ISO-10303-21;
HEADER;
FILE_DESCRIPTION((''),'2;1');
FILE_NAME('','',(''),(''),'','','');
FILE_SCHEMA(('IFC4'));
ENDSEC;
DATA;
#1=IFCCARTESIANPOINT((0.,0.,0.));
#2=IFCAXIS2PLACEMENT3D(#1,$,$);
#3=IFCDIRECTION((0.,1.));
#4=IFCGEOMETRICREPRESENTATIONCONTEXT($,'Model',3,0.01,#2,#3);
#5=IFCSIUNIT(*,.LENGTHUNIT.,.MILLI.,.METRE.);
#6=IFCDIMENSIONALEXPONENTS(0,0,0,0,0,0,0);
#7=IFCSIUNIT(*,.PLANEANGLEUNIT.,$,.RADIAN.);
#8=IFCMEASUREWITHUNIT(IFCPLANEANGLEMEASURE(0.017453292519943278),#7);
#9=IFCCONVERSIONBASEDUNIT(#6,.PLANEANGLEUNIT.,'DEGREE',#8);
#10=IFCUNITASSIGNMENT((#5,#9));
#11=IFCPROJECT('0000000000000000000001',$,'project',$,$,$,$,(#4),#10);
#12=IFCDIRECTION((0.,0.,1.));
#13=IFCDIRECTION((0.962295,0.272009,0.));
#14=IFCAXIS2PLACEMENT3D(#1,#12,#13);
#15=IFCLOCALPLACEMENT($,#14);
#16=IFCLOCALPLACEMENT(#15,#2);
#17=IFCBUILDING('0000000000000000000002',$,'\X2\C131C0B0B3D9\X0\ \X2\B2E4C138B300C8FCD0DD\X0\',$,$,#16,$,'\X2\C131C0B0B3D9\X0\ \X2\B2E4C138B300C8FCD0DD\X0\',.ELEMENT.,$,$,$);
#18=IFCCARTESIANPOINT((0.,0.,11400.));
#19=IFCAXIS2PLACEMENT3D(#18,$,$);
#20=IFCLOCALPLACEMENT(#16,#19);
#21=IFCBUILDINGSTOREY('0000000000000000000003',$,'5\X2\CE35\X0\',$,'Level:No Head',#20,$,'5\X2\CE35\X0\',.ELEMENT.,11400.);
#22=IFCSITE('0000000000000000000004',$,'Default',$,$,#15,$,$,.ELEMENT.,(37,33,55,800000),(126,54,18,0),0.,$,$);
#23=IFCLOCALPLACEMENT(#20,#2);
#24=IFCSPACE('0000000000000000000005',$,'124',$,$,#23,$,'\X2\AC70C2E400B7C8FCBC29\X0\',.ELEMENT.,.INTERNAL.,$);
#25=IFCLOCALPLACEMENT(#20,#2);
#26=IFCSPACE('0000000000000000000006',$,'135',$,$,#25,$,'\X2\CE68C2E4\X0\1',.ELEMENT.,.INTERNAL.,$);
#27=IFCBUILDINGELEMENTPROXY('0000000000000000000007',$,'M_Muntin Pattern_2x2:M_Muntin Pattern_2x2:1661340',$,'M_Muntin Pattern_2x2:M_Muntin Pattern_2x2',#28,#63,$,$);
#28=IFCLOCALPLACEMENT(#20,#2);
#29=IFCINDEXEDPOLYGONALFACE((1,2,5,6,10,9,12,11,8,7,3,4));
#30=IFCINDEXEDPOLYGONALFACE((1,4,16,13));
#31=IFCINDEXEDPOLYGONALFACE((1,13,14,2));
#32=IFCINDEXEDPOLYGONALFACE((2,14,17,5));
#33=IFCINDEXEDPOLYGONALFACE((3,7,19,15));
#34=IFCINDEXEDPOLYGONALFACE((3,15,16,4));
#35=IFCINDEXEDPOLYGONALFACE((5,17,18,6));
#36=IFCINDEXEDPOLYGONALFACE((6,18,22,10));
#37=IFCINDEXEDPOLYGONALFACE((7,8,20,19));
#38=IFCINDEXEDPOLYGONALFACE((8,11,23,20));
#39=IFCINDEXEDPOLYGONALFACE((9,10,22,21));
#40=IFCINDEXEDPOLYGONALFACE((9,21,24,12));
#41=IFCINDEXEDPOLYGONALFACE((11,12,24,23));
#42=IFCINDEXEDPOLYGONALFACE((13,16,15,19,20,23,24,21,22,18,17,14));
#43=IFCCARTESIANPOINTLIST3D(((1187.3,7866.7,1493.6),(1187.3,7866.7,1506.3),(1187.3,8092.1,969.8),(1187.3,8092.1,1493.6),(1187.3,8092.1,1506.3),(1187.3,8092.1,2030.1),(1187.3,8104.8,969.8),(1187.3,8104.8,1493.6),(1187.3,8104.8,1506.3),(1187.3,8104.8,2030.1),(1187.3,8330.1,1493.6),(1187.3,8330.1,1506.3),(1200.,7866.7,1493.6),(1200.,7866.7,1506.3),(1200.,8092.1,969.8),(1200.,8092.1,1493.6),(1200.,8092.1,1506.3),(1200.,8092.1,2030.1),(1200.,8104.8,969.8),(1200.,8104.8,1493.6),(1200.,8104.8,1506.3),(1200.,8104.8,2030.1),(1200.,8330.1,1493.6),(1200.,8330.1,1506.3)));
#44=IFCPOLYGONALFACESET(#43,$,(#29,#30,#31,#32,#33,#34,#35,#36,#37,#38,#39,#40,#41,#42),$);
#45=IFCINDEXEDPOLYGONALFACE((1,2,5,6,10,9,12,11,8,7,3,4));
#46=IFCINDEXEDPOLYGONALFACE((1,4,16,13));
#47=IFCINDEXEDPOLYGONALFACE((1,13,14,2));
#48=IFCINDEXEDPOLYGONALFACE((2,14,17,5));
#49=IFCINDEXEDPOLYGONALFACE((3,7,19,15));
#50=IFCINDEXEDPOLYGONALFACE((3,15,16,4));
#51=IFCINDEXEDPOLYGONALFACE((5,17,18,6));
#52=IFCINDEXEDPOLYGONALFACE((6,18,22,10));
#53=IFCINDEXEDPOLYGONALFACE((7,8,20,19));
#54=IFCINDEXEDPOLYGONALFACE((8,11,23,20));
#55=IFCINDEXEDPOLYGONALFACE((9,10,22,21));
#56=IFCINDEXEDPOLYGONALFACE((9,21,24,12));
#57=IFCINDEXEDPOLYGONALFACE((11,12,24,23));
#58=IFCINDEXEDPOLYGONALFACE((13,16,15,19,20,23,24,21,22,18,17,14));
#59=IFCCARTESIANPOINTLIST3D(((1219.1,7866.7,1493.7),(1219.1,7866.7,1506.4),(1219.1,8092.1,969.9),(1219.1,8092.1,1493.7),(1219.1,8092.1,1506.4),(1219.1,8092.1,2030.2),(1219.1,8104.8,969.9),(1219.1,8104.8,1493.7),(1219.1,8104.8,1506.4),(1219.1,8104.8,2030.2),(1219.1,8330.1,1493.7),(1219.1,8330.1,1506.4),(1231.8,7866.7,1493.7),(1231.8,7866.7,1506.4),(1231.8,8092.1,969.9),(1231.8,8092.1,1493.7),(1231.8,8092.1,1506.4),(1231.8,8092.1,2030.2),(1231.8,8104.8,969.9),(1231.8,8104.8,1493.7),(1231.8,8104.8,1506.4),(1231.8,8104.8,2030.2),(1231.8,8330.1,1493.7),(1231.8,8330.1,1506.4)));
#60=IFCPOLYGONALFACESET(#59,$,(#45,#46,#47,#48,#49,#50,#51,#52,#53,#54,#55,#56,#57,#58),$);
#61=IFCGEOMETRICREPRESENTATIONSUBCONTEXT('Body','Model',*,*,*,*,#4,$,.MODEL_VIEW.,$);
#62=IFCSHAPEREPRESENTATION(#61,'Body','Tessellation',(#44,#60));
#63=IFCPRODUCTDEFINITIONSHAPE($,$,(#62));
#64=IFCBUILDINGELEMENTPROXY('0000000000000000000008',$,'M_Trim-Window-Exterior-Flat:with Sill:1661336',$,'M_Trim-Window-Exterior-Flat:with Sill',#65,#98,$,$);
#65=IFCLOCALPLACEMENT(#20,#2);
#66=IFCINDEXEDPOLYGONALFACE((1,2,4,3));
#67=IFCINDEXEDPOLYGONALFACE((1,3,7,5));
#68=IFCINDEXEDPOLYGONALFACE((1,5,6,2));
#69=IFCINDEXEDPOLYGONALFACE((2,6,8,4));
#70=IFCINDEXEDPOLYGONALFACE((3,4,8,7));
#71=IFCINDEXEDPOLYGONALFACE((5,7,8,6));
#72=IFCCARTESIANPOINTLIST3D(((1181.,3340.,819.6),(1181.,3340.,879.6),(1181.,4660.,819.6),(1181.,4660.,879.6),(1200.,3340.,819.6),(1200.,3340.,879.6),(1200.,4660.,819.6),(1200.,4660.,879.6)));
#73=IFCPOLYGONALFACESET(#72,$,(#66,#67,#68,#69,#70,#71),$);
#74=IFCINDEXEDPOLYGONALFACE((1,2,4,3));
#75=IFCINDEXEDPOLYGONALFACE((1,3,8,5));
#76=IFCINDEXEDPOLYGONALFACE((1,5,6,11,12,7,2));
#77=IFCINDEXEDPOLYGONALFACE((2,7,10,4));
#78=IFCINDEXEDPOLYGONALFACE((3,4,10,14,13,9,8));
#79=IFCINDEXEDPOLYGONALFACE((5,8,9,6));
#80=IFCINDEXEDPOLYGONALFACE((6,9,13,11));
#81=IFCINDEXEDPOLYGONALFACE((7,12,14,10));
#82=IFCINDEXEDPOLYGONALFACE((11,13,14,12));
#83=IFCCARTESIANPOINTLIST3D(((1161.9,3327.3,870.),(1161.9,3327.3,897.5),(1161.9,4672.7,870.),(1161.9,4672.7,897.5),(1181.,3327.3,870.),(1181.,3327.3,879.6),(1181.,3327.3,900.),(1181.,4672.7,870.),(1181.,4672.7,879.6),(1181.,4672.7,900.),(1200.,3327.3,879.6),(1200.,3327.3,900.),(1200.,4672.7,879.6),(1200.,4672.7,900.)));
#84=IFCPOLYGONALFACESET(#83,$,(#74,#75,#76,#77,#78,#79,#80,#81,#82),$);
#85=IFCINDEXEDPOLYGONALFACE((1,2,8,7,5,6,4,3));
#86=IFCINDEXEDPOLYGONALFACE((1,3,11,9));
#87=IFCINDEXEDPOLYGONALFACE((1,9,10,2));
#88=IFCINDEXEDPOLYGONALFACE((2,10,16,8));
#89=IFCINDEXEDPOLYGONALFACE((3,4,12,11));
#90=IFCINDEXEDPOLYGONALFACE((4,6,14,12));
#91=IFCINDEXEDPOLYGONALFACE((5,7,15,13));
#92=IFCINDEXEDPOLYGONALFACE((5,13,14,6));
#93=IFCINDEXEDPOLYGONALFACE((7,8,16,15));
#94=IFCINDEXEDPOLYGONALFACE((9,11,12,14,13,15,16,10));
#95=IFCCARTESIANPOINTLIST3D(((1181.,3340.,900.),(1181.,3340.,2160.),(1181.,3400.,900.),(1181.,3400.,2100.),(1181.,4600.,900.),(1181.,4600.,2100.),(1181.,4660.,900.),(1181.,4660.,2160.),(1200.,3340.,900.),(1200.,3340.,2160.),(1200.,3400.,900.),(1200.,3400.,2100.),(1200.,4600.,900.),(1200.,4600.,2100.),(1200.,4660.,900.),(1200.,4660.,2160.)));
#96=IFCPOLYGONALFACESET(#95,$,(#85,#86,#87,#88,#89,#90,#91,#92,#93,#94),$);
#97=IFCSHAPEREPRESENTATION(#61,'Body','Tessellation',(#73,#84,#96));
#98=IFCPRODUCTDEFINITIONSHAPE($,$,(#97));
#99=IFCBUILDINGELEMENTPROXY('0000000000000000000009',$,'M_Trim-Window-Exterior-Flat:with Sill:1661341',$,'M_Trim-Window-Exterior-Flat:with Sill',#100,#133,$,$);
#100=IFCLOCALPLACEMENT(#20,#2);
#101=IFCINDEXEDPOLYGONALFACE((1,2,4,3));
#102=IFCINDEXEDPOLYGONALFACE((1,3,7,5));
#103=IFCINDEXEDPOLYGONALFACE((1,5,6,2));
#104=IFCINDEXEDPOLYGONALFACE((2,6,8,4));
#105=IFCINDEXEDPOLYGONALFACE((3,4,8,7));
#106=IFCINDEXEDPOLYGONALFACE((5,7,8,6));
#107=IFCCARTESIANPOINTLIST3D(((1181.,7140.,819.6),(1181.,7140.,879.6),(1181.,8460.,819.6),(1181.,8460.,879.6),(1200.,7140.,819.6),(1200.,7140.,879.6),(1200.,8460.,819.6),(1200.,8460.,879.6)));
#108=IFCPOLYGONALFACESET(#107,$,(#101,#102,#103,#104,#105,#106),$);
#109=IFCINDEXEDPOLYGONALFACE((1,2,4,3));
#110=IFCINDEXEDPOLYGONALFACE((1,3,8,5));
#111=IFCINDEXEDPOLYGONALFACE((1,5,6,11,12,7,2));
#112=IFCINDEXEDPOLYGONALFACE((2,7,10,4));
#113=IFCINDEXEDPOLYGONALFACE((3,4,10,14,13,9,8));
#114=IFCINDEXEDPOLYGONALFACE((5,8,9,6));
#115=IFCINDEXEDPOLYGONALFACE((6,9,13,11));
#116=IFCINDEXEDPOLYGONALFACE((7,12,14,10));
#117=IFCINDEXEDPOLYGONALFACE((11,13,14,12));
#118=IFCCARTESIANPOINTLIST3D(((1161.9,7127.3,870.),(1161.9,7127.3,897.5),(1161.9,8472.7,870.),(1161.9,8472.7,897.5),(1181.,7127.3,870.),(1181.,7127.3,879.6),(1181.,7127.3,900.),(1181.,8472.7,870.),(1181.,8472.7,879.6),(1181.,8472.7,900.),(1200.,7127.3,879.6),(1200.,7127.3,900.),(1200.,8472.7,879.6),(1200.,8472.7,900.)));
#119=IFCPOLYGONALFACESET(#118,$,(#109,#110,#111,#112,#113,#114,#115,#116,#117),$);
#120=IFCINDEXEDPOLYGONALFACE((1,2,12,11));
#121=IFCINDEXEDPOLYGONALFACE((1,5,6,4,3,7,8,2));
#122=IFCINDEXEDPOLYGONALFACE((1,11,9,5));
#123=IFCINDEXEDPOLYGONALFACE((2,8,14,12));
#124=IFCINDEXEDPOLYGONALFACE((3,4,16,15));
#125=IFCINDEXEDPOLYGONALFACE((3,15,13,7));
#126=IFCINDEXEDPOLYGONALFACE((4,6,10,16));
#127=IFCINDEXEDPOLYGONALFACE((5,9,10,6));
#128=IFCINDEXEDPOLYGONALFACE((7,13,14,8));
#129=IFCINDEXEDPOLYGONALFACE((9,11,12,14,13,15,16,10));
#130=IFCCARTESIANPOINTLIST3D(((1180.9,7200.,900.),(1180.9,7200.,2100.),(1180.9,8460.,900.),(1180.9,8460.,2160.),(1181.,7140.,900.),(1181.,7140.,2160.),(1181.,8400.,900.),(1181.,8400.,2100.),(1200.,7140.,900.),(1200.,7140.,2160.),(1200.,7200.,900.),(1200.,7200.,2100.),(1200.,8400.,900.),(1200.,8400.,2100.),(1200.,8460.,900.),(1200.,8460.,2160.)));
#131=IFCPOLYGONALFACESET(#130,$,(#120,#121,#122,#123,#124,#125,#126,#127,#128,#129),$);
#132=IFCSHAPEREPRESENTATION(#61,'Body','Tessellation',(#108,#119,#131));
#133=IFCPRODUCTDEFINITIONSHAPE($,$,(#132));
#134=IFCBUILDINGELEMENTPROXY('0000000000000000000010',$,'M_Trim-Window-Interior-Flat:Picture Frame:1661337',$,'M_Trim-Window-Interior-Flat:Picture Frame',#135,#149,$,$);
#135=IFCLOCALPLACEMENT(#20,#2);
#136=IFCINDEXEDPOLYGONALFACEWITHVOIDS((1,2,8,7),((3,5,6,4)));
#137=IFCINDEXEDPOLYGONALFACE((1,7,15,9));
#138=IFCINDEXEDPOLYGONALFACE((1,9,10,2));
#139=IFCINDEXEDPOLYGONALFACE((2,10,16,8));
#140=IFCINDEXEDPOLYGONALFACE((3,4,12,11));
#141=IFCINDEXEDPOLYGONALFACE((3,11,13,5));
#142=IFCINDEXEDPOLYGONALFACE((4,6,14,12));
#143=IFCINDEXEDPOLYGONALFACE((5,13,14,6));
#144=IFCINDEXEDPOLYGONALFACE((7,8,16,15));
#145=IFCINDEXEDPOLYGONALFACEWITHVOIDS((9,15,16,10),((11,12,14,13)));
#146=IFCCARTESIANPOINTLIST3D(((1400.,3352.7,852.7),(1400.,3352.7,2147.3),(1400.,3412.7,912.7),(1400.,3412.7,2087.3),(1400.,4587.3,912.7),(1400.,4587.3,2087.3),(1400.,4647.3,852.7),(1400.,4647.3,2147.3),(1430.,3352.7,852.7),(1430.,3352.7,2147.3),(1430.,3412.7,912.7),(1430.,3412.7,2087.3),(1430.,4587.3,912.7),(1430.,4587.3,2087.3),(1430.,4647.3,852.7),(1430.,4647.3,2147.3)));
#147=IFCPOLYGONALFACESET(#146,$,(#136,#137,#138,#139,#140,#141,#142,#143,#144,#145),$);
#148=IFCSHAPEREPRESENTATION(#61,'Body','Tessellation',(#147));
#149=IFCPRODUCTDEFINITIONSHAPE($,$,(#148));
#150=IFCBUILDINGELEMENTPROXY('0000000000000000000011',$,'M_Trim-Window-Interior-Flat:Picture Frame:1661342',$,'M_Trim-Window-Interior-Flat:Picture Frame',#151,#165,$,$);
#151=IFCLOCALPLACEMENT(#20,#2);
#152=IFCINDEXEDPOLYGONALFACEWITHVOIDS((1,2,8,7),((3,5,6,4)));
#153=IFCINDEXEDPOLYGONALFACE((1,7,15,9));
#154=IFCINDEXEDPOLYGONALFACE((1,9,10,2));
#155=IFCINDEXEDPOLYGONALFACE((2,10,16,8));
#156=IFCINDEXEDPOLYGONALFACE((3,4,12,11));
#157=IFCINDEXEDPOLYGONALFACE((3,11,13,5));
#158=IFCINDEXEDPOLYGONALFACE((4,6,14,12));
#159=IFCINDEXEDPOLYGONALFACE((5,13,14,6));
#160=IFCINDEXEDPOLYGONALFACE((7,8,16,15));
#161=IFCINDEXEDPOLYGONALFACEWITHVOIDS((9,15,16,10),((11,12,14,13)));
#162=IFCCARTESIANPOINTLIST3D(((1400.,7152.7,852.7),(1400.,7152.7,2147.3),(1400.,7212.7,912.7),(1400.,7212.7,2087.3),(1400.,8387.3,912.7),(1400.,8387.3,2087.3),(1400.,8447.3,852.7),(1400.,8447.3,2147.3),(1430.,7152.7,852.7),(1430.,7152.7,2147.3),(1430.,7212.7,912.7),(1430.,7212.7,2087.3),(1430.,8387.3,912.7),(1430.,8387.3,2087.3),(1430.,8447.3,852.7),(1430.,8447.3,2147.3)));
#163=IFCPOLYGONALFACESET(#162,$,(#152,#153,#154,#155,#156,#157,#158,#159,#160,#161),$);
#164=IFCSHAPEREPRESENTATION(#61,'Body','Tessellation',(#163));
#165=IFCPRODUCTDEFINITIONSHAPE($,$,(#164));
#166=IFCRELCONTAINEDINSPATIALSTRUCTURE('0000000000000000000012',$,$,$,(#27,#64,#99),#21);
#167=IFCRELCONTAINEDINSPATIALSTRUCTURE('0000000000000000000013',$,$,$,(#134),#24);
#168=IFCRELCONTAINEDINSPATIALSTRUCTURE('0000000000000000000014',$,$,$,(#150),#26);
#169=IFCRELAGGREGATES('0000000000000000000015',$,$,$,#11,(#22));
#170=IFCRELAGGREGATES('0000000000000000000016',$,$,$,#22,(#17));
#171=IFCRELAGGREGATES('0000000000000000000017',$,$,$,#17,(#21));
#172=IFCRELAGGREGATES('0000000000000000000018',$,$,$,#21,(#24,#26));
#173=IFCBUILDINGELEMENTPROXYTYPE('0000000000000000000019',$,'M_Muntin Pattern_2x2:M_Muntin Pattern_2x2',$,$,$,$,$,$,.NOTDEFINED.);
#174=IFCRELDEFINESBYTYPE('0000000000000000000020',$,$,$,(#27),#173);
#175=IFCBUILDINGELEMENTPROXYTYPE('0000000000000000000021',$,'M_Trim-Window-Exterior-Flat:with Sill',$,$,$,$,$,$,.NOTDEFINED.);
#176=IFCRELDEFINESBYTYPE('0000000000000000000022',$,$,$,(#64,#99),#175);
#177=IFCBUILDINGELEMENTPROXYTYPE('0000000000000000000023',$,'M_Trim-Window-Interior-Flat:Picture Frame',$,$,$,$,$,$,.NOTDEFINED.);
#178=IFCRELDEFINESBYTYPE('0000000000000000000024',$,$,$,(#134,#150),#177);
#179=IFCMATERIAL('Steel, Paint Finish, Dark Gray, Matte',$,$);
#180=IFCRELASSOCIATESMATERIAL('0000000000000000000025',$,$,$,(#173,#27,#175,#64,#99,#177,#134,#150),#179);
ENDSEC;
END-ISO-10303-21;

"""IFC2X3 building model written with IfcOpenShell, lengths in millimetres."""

from ifc_helpers import new_model, entity, si_unit, converted_unit, direction, frame, frame_2d, origin, place, context, subcontext, project, spatial, polyline, rectangle, outline, extrude, source, transform, mapped, material, type_object, type_shapes, element, save


model = new_model("IFC2X3")

# Units and contexts
model_context = context("Model", 3, precision=0.01, world=origin(), true_north=direction((0.0, 1.0)))
body_context = subcontext(model_context, "Body", "Model", "MODEL_VIEW")
ifc_project = project(units=[si_unit("LENGTHUNIT", "METRE", prefix="MILLI"), converted_unit("PLANEANGLEUNIT", "DEGREE", entity("IfcPlaneAngleMeasure", 0.017453292519943278), si_unit("PLANEANGLEUNIT", "RADIAN"), dimensions=[0, 0, 0, 0, 0, 0, 0])], contexts=[model_context])

# Site, building, storey
site_placement = place(None, frame((0.0, 0.0, 0.0), z_axis=(0.0, 0.0, 1.0), x_axis=(0.962295, 0.272009, 0.0)))
site = spatial("IfcSite", under=ifc_project, at=site_placement, Name="Default", CompositionType="ELEMENT", RefLatitude=(37, 33, 55, 800000), RefLongitude=(126, 54, 18, 0), RefElevation=0.0)
building_placement = place(site_placement, origin())
building = spatial("IfcBuilding", under=site, at=building_placement, Name="성산동 다세대주택", LongName="성산동 다세대주택", CompositionType="ELEMENT")
storey_placement = place(building_placement, frame((0.0, 0.0, 11400.0)))
storey = spatial("IfcBuildingStorey", under=building, at=storey_placement, Name="5층", ObjectType="Level:No Head", LongName="5층", CompositionType="ELEMENT", Elevation=11400.0)

# Shared definitions
space_1_placement = place(storey_placement, origin())
space_1 = spatial("IfcSpace", under=storey, at=space_1_placement, Name="124", LongName="거실·주방", CompositionType="ELEMENT", InteriorOrExteriorSpace="INTERNAL")

# Shared definitions
space_2_placement = place(storey_placement, origin())
space_2 = spatial("IfcSpace", under=storey, at=space_2_placement, Name="135", LongName="침실1", CompositionType="ELEMENT", InteriorOrExteriorSpace="INTERNAL")

# Building element proxies
ifc_material_1 = material(Name="Steel, Paint Finish, Dark Gray, Matte")
building_element_proxy_type_1 = type_object("IfcBuildingElementProxyType", Name="M_Muntin Pattern_2x2:M_Muntin Pattern_2x2", PredefinedType="NOTDEFINED", material=ifc_material_1)
shared_shape_1 = source(origin(), body_context, "Body", "SweptSolid", [
    extrude(outline(polyline([(6.4, -6.4), (530.1, -6.4), (530.1, 6.3), (6.4, 6.3), (6.4, 231.7), (-6.3, 231.7), (-6.3, 6.3), (-530.2, 6.3), (-530.2, -6.4), (-6.3, -6.4), (-6.3, -231.7), (6.4, -231.7), (6.4, -6.4)])), frame((0.0, -22.2, 530.1), z_axis=(0.0, 1.0, 0.0), x_axis=(0.0, 0.0, 1.0)), (0.0, 0.0, 1.0), 12.7),
    extrude(outline(polyline([(6.4, -6.4), (530.2, -6.4), (530.2, 6.3), (6.4, 6.3), (6.4, 231.7), (-6.3, 231.7), (-6.3, 6.3), (-530.2, 6.3), (-530.2, -6.4), (-6.3, -6.4), (-6.3, -231.7), (6.4, -231.7), (6.4, -6.4)])), frame((0.0, 9.5, 530.2), z_axis=(0.0, 1.0, 0.0), x_axis=(0.0, 0.0, 1.0)), (0.0, 0.0, 1.0), 12.7),
])
type_shapes(building_element_proxy_type_1, [shared_shape_1])
for number, where, z_axis, x_axis, name in (
    (1, (1209.5, 8098.4, 969.9), (0.0, 0.0, 1.0), (0.0, -1.0, 0.0), "M_Muntin Pattern_2x2:M_Muntin Pattern_2x2:1661340"),
):
    element("IfcBuildingElementProxy", number, at=place(storey_placement, frame(where, z_axis=z_axis, x_axis=x_axis)), inside=storey, type_object=building_element_proxy_type_1, material=ifc_material_1, Name=name, ObjectType="M_Muntin Pattern_2x2:M_Muntin Pattern_2x2", context=body_context, shape_type="MappedRepresentation", body=[
        mapped(shared_shape_1, transform((0.0, 0.0, 0.0), scale=1.0)),
    ])
building_element_proxy_type_2 = type_object("IfcBuildingElementProxyType", Name="M_Trim-Window-Exterior-Flat:with Sill", PredefinedType="NOTDEFINED", material=ifc_material_1)
shared_shape_2 = source(origin(), body_context, "Body", "SweptSolid", [
    extrude(rectangle(XDim=1320.0, YDim=60.0, at=frame_2d((0.0, 0.0), x_axis=(1.0, 0.0))), frame((0.0, -1250.4, 0.0), z_axis=(0.0, 0.0, 1.0), x_axis=(-1.0, 0.0, 0.0)), (0.0, 0.0, 1.0), 19.0),
    extrude(outline(polyline([(-19.0, -15.2), (0.0, -15.2), (0.0, -5.7), (19.0, -5.7), (19.0, 14.8), (0.0, 14.8), (-19.0, 12.3), (-19.0, -15.2)])), frame((-672.7, -1214.8, 19.0), z_axis=(1.0, 0.0, 0.0), x_axis=(0.0, 0.0, -1.0)), (0.0, 0.0, 1.0), 1345.4),
    extrude(outline(polyline([(-645.0, -660.0), (615.0, -660.0), (615.0, -600.0), (-585.0, -600.0), (-585.0, 600.0), (615.0, 600.0), (615.0, 660.0), (-645.0, 660.0), (-645.0, -660.0)])), frame((0.0, -585.0, 0.0), z_axis=(0.0, 0.0, 1.0), x_axis=(0.0, -1.0, 0.0)), (0.0, 0.0, 1.0), 19.0),
])
type_shapes(building_element_proxy_type_2, [shared_shape_2])
for number, where, z_axis, x_axis, name in (
    (2, (1200.0, 4000.0, 2100.0), (-1.0, 0.0, 0.0), (0.0, -1.0, 0.0), "M_Trim-Window-Exterior-Flat:with Sill:1661336"),
    (3, (1200.0, 7800.0, 2100.0), (-1.0, 0.0, 0.0), (0.0, -1.0, 0.0), "M_Trim-Window-Exterior-Flat:with Sill:1661341"),
):
    element("IfcBuildingElementProxy", number, at=place(storey_placement, frame(where, z_axis=z_axis, x_axis=x_axis)), inside=storey, type_object=building_element_proxy_type_2, material=ifc_material_1, Name=name, ObjectType="M_Trim-Window-Exterior-Flat:with Sill", context=body_context, shape_type="MappedRepresentation", body=[
        mapped(shared_shape_2, transform((0.0, 0.0, 0.0), scale=1.0)),
    ])
building_element_proxy_type_3 = type_object("IfcBuildingElementProxyType", Name="M_Trim-Window-Interior-Flat:Picture Frame", PredefinedType="NOTDEFINED", material=ifc_material_1)
shared_shape_3 = source(origin(), body_context, "Body", "SweptSolid", [
    extrude(outline(polyline([(-647.3, -647.3), (647.3, -647.3), (647.3, 647.3), (-647.3, 647.3), (-647.3, -647.3)]), holes=[polyline([(-587.3, -587.3), (-587.3, 587.3), (587.3, 587.3), (587.3, -587.3), (-587.3, -587.3)])]), frame((0.0, -600.0, 0.0), z_axis=(0.0, 0.0, 1.0), x_axis=(-1.0, 0.0, 0.0)), (0.0, 0.0, 1.0), 30.0),
])
type_shapes(building_element_proxy_type_3, [shared_shape_3])
proxy_1_placement = place(space_1_placement, frame((1400.0, 4000.0, 2100.0), z_axis=(1.0, 0.0, 0.0), x_axis=(0.0, 1.0, 0.0)))
element("IfcBuildingElementProxy", 4, at=proxy_1_placement, inside=space_1, type_object=building_element_proxy_type_3, material=ifc_material_1, Name="M_Trim-Window-Interior-Flat:Picture Frame:1661337", ObjectType="M_Trim-Window-Interior-Flat:Picture Frame", context=body_context, shape_type="MappedRepresentation", body=[
    mapped(shared_shape_3, transform((0.0, 0.0, 0.0), scale=1.0)),
])
proxy_2_placement = place(space_2_placement, frame((1400.0, 7800.0, 2100.0), z_axis=(1.0, 0.0, 0.0), x_axis=(0.0, 1.0, 0.0)))
element("IfcBuildingElementProxy", 5, at=proxy_2_placement, inside=space_2, type_object=building_element_proxy_type_3, material=ifc_material_1, Name="M_Trim-Window-Interior-Flat:Picture Frame:1661342", ObjectType="M_Trim-Window-Interior-Flat:Picture Frame", context=body_context, shape_type="MappedRepresentation", body=[
    mapped(shared_shape_3, transform((0.0, 0.0, 0.0), scale=1.0)),
])

save(model, "model.ifc")
